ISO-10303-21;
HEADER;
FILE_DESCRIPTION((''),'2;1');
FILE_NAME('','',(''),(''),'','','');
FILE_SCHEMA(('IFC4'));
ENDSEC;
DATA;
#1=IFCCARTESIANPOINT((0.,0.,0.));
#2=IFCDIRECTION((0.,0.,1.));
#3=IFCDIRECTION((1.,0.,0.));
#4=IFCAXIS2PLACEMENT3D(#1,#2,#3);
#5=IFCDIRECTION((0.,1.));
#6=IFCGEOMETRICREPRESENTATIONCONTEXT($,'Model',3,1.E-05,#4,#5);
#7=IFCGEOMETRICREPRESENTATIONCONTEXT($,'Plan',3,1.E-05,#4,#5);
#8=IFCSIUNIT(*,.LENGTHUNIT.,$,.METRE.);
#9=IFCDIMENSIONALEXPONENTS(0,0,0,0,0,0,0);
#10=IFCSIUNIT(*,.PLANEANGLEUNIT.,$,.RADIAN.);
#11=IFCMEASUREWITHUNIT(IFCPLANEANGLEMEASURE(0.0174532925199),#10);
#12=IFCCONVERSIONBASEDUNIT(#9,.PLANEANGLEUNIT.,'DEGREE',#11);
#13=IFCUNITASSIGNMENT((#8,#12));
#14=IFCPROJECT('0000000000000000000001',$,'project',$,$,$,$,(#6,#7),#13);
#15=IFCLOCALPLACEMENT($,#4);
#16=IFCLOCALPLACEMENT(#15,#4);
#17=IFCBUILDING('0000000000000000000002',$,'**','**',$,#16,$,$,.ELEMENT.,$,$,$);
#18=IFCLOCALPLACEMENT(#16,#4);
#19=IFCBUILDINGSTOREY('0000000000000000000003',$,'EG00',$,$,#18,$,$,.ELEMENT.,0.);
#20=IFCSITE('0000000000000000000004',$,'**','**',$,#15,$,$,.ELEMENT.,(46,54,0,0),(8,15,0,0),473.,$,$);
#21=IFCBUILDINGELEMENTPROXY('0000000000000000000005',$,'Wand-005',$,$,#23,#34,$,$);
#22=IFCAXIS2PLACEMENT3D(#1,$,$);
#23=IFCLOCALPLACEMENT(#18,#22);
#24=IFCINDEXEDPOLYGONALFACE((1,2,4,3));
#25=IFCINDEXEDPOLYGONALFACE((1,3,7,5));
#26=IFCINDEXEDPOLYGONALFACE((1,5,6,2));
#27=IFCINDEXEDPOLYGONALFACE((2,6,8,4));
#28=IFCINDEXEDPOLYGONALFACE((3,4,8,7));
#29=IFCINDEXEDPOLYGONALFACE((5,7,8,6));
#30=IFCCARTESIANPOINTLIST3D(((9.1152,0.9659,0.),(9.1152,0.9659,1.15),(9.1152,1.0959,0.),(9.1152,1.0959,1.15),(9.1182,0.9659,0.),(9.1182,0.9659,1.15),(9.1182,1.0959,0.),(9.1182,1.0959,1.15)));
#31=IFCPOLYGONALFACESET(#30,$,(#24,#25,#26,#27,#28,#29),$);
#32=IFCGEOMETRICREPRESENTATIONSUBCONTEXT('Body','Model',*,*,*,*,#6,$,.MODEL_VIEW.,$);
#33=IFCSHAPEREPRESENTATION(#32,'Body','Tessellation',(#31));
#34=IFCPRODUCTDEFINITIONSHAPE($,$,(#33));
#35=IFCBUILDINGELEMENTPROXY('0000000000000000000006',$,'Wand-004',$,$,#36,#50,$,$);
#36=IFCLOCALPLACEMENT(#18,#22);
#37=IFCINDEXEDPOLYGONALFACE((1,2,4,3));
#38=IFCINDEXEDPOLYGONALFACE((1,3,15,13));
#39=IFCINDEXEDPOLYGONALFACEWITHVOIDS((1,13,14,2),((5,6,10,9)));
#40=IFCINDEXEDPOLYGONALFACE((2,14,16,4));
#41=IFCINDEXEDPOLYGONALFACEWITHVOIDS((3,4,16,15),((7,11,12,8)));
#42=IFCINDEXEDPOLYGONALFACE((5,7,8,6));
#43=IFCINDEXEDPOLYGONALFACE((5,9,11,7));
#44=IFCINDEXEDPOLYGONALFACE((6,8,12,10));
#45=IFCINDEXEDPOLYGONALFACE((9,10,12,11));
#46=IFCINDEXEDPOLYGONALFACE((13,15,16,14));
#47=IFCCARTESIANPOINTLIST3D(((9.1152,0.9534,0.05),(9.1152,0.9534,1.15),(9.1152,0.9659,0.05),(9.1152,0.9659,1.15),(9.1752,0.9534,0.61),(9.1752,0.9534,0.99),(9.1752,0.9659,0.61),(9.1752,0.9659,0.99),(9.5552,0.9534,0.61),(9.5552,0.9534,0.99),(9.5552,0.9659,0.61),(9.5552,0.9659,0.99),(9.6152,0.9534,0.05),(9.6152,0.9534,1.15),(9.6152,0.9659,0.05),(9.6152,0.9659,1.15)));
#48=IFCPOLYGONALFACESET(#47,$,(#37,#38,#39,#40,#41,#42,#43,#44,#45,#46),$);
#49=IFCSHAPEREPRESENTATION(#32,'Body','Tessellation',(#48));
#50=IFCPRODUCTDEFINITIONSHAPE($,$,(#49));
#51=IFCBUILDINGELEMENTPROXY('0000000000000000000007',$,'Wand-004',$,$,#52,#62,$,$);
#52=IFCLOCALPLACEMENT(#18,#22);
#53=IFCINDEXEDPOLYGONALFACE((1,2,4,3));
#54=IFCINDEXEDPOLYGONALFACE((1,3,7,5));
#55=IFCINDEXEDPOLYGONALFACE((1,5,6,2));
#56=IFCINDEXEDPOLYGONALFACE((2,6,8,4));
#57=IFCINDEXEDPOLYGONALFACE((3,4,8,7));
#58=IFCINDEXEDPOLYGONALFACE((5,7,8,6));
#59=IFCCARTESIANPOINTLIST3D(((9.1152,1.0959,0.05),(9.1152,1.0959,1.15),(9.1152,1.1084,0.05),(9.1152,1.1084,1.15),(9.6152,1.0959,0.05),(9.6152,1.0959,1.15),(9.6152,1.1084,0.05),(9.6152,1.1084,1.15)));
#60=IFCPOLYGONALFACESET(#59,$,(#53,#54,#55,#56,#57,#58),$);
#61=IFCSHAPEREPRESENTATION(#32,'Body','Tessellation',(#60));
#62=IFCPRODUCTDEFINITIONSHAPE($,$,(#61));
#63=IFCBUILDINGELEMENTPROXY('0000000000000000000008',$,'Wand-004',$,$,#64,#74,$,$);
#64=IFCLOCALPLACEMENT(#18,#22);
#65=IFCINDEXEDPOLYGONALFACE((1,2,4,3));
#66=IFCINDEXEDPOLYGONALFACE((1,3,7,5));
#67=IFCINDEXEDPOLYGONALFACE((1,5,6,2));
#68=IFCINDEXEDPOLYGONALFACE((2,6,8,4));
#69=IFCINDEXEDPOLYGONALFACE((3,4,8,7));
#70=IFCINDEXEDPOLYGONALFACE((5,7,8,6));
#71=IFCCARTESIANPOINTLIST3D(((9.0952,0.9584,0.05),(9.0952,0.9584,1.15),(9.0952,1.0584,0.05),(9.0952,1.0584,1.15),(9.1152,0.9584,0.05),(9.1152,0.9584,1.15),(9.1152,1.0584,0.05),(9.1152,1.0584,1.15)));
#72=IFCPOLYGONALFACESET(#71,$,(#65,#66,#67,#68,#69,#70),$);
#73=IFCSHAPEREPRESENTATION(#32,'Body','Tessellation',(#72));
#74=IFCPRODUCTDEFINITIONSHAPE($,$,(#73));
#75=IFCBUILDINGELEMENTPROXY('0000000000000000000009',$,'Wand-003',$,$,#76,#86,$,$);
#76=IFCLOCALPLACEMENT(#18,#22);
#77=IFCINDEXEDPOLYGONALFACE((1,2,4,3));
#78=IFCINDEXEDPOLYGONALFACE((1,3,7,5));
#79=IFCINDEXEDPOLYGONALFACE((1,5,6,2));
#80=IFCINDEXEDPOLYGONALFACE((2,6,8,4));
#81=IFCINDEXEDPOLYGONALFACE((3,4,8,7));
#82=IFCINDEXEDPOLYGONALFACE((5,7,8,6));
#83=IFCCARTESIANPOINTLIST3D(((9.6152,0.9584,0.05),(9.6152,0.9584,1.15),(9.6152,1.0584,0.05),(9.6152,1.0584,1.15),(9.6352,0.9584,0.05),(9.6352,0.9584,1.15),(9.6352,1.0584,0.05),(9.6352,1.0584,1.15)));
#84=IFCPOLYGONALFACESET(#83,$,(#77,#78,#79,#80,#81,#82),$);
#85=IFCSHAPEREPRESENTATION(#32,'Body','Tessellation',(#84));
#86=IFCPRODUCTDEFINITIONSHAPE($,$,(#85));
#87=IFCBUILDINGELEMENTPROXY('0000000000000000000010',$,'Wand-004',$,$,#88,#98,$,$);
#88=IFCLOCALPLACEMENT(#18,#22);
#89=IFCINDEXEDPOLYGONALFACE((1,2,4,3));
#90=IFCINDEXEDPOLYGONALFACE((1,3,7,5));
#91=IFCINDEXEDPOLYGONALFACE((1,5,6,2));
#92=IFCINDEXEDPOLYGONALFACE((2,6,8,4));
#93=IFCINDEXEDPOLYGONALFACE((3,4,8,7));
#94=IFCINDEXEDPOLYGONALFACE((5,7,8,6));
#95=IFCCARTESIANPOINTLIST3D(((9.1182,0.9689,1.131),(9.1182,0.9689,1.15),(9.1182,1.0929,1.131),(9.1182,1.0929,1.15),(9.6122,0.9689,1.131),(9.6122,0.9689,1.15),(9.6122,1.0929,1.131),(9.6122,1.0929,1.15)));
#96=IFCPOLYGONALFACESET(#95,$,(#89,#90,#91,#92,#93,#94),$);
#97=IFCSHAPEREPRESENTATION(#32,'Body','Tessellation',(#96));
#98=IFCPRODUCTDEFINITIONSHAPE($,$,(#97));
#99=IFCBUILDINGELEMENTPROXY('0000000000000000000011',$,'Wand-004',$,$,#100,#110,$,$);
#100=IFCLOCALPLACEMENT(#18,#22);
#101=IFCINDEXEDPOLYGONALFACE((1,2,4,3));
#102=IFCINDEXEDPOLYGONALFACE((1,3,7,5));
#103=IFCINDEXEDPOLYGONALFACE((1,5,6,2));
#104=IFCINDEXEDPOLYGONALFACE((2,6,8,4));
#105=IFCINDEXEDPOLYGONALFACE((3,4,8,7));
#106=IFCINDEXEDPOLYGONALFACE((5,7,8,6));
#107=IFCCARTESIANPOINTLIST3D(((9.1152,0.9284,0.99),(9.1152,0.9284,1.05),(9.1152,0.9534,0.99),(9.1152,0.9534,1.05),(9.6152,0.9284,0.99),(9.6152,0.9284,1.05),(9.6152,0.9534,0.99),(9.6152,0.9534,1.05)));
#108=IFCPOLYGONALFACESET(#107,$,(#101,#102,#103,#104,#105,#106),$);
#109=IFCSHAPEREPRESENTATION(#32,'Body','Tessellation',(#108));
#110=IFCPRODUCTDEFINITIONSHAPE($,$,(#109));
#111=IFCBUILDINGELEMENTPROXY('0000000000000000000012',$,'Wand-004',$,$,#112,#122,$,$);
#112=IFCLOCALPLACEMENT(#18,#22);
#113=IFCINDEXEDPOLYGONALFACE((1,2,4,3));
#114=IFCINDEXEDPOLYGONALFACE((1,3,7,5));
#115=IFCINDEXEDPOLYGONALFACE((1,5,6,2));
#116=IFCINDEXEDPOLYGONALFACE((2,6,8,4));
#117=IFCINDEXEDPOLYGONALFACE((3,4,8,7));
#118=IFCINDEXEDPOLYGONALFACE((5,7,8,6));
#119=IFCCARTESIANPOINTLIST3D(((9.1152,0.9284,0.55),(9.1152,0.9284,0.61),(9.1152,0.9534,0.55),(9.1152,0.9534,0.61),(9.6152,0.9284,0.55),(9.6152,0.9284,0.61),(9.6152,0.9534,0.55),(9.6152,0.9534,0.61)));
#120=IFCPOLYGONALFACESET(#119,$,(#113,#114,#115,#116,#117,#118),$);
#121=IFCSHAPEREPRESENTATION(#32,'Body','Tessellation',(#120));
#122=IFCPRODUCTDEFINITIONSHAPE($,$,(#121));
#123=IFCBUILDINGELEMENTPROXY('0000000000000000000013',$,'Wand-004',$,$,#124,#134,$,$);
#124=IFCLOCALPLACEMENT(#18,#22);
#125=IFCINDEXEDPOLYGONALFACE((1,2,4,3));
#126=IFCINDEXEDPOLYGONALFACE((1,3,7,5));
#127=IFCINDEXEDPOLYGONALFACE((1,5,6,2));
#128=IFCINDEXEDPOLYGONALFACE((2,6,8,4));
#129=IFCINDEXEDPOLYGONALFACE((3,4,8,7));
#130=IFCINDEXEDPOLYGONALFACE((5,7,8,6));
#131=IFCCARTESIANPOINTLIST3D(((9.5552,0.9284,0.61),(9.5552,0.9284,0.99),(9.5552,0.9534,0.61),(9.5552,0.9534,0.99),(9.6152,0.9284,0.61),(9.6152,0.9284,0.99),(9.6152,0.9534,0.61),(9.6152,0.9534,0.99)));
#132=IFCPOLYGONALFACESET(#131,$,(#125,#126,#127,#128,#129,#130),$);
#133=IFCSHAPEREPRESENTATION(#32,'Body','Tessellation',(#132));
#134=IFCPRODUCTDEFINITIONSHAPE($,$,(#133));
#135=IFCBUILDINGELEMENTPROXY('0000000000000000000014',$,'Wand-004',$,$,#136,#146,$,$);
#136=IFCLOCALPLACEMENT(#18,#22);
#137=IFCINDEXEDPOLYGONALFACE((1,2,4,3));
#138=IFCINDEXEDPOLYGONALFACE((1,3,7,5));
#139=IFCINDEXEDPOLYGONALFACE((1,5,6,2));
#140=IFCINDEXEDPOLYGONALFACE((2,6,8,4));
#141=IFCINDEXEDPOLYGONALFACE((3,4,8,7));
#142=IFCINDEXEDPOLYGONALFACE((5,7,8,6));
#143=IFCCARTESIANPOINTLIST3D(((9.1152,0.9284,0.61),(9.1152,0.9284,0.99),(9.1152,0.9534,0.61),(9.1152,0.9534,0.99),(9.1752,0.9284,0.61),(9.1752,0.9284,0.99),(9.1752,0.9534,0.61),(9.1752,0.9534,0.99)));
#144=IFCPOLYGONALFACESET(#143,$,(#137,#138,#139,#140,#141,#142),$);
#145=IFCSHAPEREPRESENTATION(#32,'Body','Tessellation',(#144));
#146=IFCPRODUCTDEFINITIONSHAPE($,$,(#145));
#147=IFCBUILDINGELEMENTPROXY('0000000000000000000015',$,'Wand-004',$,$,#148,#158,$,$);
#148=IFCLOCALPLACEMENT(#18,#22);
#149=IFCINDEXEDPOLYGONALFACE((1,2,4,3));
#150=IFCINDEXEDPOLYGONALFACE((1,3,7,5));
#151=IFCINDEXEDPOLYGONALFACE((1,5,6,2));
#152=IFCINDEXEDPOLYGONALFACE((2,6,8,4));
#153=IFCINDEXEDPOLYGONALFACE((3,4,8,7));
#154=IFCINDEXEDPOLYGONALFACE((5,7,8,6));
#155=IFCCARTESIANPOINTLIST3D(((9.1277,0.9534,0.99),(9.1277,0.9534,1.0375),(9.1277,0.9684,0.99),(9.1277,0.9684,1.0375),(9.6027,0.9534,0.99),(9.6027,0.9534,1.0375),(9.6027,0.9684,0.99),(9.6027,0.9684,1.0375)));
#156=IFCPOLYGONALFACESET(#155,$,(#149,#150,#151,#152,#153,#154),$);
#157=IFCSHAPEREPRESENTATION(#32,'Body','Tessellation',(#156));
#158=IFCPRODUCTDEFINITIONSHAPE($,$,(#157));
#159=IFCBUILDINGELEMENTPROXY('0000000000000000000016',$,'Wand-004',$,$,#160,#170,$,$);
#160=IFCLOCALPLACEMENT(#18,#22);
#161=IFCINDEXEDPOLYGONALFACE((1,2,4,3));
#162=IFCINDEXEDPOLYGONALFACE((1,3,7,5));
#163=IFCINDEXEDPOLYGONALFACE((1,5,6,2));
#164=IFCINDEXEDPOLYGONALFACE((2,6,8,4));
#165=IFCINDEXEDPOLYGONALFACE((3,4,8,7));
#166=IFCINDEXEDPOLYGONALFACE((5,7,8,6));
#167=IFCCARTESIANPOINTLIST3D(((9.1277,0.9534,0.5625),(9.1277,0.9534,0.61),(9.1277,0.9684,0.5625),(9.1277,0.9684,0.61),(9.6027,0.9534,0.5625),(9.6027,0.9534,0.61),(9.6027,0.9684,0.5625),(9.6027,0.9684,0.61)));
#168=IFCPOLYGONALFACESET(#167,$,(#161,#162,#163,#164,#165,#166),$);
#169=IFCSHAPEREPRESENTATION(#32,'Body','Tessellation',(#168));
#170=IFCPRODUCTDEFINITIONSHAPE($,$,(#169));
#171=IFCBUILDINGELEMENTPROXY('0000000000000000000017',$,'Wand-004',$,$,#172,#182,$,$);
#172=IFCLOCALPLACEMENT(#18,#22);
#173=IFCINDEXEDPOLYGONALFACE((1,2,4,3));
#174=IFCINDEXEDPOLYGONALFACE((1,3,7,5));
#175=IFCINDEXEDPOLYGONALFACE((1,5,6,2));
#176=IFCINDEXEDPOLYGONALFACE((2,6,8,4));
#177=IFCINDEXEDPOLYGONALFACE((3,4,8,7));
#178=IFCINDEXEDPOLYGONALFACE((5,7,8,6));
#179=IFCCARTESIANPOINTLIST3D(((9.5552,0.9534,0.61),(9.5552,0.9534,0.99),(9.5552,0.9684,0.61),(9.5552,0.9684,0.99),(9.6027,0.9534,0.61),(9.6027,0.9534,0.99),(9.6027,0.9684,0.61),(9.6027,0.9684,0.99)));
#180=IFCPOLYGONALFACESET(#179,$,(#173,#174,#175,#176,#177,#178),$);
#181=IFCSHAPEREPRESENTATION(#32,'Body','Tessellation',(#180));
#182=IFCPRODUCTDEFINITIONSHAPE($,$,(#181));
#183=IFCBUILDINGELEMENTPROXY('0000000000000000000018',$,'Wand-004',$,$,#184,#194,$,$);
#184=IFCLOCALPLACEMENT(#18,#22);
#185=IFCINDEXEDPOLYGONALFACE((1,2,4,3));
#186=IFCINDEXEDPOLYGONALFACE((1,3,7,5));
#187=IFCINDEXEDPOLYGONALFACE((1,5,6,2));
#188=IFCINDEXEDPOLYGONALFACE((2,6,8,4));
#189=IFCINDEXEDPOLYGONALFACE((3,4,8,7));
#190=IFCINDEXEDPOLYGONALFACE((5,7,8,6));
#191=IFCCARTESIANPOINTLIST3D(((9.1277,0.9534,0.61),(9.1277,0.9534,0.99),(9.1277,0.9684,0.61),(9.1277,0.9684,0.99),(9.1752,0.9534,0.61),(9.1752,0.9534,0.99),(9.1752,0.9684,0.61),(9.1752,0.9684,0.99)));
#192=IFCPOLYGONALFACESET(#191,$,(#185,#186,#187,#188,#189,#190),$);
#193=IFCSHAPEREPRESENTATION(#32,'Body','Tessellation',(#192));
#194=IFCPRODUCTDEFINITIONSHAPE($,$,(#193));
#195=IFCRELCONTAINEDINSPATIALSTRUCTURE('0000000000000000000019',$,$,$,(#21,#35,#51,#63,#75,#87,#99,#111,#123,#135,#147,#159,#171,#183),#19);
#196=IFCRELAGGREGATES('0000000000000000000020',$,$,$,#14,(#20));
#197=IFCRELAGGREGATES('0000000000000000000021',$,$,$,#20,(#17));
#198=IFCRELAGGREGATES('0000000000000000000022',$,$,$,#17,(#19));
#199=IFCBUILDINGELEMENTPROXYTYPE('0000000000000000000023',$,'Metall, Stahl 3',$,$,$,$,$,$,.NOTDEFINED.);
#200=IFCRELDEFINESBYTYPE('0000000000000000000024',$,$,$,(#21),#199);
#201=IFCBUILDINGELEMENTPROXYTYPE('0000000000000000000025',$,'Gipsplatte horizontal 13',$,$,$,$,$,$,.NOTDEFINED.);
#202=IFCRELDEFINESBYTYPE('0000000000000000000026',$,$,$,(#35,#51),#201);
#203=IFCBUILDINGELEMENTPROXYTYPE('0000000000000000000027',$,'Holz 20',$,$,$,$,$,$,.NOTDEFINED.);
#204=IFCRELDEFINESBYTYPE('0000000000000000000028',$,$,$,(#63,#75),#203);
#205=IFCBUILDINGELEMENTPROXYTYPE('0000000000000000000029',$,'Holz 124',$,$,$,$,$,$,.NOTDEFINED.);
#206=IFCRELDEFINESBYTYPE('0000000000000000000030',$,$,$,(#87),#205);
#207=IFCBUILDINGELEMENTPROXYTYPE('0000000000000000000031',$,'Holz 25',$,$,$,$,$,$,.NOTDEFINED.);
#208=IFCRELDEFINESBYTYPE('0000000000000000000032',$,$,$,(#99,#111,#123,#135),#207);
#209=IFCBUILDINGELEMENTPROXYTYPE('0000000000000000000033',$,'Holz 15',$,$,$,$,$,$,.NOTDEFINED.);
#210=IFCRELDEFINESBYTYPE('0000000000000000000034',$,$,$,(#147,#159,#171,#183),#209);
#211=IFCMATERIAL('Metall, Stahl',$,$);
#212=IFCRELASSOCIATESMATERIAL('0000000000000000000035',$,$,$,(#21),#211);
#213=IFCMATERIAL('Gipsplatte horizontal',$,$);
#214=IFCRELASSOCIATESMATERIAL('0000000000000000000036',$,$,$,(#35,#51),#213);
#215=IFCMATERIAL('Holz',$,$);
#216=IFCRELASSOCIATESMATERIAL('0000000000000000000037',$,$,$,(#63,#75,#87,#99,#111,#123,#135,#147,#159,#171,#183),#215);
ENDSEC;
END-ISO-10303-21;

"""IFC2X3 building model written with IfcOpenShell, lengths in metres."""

from ifc_helpers import new_model, entity, si_unit, converted_unit, direction, frame, origin_with_axes, origin_2d_with_axis, place, context, subcontext, project, spatial, polyline, rectangle, outline, extrude, material, type_object, element, save


model = new_model("IFC2X3")

# Units and contexts
model_context = context("Model", 3, precision=1e-05, world=origin_with_axes(), true_north=direction((0.0, 1.0)))
plan_context = context("Plan", 3, precision=1e-05, world=origin_with_axes(), true_north=direction((0.0, 1.0)))
body_context = subcontext(model_context, "Body", "Model", "MODEL_VIEW")
ifc_project = project(units=[si_unit("LENGTHUNIT", "METRE"), converted_unit("PLANEANGLEUNIT", "DEGREE", entity("IfcPlaneAngleMeasure", 0.0174532925199), si_unit("PLANEANGLEUNIT", "RADIAN"), dimensions=[0, 0, 0, 0, 0, 0, 0])], contexts=[model_context, plan_context])

# Site, building, storey
site_placement = place(None, origin_with_axes())
site = spatial("IfcSite", under=ifc_project, at=site_placement, Name="**", Description="**", CompositionType="ELEMENT", RefLatitude=(46, 54, 0, 0), RefLongitude=(8, 15, 0, 0), RefElevation=473.0)
building_placement = place(site_placement, origin_with_axes())
building = spatial("IfcBuilding", under=site, at=building_placement, Name="**", Description="**", CompositionType="ELEMENT")
storey_placement = place(building_placement, origin_with_axes())
storey = spatial("IfcBuildingStorey", under=building, at=storey_placement, Name="EG00", CompositionType="ELEMENT", Elevation=0.0)

# Building element proxy
ifc_material_1 = material(Name="Metall, Stahl")
building_element_proxy_type_1 = type_object("IfcBuildingElementProxyType", Name="Metall, Stahl 3", PredefinedType="NOTDEFINED")
proxy_1_placement = place(storey_placement, frame((9.1152, 1.0959, 0.0), z_axis=(0.0, 0.0, 1.0), x_axis=(0.0, -1.0, 0.0)))
element("IfcBuildingElementProxy", 1, at=proxy_1_placement, inside=storey, type_object=building_element_proxy_type_1, material=ifc_material_1, Name="Wand-005", context=body_context, shape_type="SweptSolid", body=[
    extrude(outline(polyline([(0.0, 0.0), (0.13, 0.0), (0.13, 0.003), (0.0, 0.003), (0.0, 0.0)])), origin_with_axes(), (0.0, 0.0, 1.0), 1.15),
])

# Building element proxy, opening
ifc_material_2 = material(Name="Gipsplatte horizontal")
building_element_proxy_type_2 = type_object("IfcBuildingElementProxyType", Name="Gipsplatte horizontal 13", PredefinedType="NOTDEFINED")
proxy_2_placement = place(storey_placement, frame((9.1152, 0.9534, 0.05), z_axis=(0.0, 0.0, 1.0), x_axis=(1.0, 0.0, 0.0)))
proxy_2 = element("IfcBuildingElementProxy", 2, at=proxy_2_placement, inside=storey, type_object=building_element_proxy_type_2, material=ifc_material_2, Name="Wand-004", context=body_context, shape_type="SweptSolid", body=[
    extrude(outline(polyline([(0.0, 0.0), (0.5, 0.0), (0.5, 0.0125), (0.0, 0.0125), (0.0, 0.0)])), origin_with_axes(), (0.0, 0.0, 1.0), 1.1),
])
opening_placement = place(proxy_2_placement, frame((-9.1152, -0.9534, -0.05), z_axis=(0.0, 0.0, 1.0), x_axis=(1.0, 0.0, 0.0)))
element("IfcOpeningElement", 3, at=opening_placement, cuts=proxy_2, context=body_context, shape_type="SweptSolid", body=[
    extrude(rectangle(XDim=0.38, YDim=0.38, at=origin_2d_with_axis()), frame((9.3652, 0.9284, 0.8), z_axis=(0.0, -1.0, 0.0), x_axis=(1.0, 0.0, 0.0)), (0.0, 0.0, -1.0), 0.05),
])

# Building element proxies
proxy_3_placement = place(storey_placement, frame((9.1152, 1.1084, 0.05), z_axis=(0.0, 0.0, 1.0), x_axis=(1.0, 0.0, 0.0)))
element("IfcBuildingElementProxy", 4, at=proxy_3_placement, inside=storey, type_object=building_element_proxy_type_2, material=ifc_material_2, Name="Wand-004", context=body_context, shape_type="SweptSolid", body=[
    extrude(outline(polyline([(0.0, -0.0125), (0.5, -0.0125), (0.5, 0.0), (0.0, 0.0), (0.0, -0.0125)])), origin_with_axes(), (0.0, 0.0, 1.0), 1.1),
])
ifc_material_3 = material(Name="Holz")
building_element_proxy_type_3 = type_object("IfcBuildingElementProxyType", Name="Holz 20", PredefinedType="NOTDEFINED")
proxy_4_placement = place(storey_placement, frame((9.0952, 1.0584, 0.05), z_axis=(0.0, 0.0, 1.0), x_axis=(0.0, -1.0, 0.0)))
element("IfcBuildingElementProxy", 5, at=proxy_4_placement, inside=storey, type_object=building_element_proxy_type_3, material=ifc_material_3, Name="Wand-004", context=body_context, shape_type="SweptSolid", body=[
    extrude(outline(polyline([(0.0, 0.0), (0.1, 0.0), (0.1, 0.02), (0.0, 0.02), (0.0, 0.0)])), origin_with_axes(), (0.0, 0.0, 1.0), 1.1),
])
proxy_5_placement = place(storey_placement, frame((9.6352, 1.0584, 0.05), z_axis=(0.0, 0.0, 1.0), x_axis=(0.0, -1.0, 0.0)))
element("IfcBuildingElementProxy", 6, at=proxy_5_placement, inside=storey, type_object=building_element_proxy_type_3, material=ifc_material_3, Name="Wand-003", context=body_context, shape_type="SweptSolid", body=[
    extrude(outline(polyline([(0.0, -0.02), (0.1, -0.02), (0.1, 0.0), (0.0, 0.0), (0.0, -0.02)])), origin_with_axes(), (0.0, 0.0, 1.0), 1.1),
])
building_element_proxy_type_4 = type_object("IfcBuildingElementProxyType", Name="Holz 124", PredefinedType="NOTDEFINED")
proxy_6_placement = place(storey_placement, frame((9.1182, 1.0929, 1.131), z_axis=(0.0, 0.0, 1.0), x_axis=(1.0, 0.0, 0.0)))
element("IfcBuildingElementProxy", 7, at=proxy_6_placement, inside=storey, type_object=building_element_proxy_type_4, material=ifc_material_3, Name="Wand-004", context=body_context, shape_type="SweptSolid", body=[
    extrude(outline(polyline([(0.0, -0.124), (0.494, -0.124), (0.494, 0.0), (0.0, 0.0), (0.0, -0.124)])), origin_with_axes(), (0.0, 0.0, 1.0), 0.019),
])
building_element_proxy_type_5 = type_object("IfcBuildingElementProxyType", Name="Holz 25", PredefinedType="NOTDEFINED")
for number, where, z_axis, x_axis, name in (
    (8, (9.6152, 0.9534, 0.99), (0.0, 0.0, 1.0), (-1.0, 0.0, 0.0), "Wand-004"),
    (9, (9.6152, 0.9534, 0.55), (0.0, 0.0, 1.0), (-1.0, 0.0, 0.0), "Wand-004"),
):
    element("IfcBuildingElementProxy", number, at=place(storey_placement, frame(where, z_axis=z_axis, x_axis=x_axis)), inside=storey, type_object=building_element_proxy_type_5, material=ifc_material_3, Name=name, context=body_context, shape_type="SweptSolid", body=[
        extrude(outline(polyline([(0.0, 0.0), (0.5, 0.0), (0.5, 0.025), (0.0, 0.025), (0.0, 0.0)])), origin_with_axes(), (0.0, 0.0, 1.0), 0.06),
    ])
for number, where, z_axis, x_axis, name in (
    (10, (9.5552, 0.9284, 0.61), (0.0, 0.0, 1.0), (1.0, 0.0, 0.0), "Wand-004"),
    (11, (9.1152, 0.9284, 0.61), (0.0, 0.0, 1.0), (1.0, 0.0, 0.0), "Wand-004"),
):
    element("IfcBuildingElementProxy", number, at=place(storey_placement, frame(where, z_axis=z_axis, x_axis=x_axis)), inside=storey, type_object=building_element_proxy_type_5, material=ifc_material_3, Name=name, context=body_context, shape_type="SweptSolid", body=[
        extrude(outline(polyline([(0.0, 0.0), (0.06, 0.0), (0.06, 0.025), (0.0, 0.025), (0.0, 0.0)])), origin_with_axes(), (0.0, 0.0, 1.0), 0.38),
    ])
building_element_proxy_type_6 = type_object("IfcBuildingElementProxyType", Name="Holz 15", PredefinedType="NOTDEFINED")
for number, where, z_axis, x_axis, name in (
    (12, (9.6027, 0.9684, 0.99), (0.0, 0.0, 1.0), (-1.0, 0.0, 0.0), "Wand-004"),
    (13, (9.6027, 0.9684, 0.5625), (0.0, 0.0, 1.0), (-1.0, 0.0, 0.0), "Wand-004"),
):
    element("IfcBuildingElementProxy", number, at=place(storey_placement, frame(where, z_axis=z_axis, x_axis=x_axis)), inside=storey, type_object=building_element_proxy_type_6, material=ifc_material_3, Name=name, context=body_context, shape_type="SweptSolid", body=[
        extrude(outline(polyline([(0.0, 0.0), (0.475, 0.0), (0.475, 0.015), (0.0, 0.015), (0.0, 0.0)])), origin_with_axes(), (0.0, 0.0, 1.0), 0.0475),
    ])
for number, where, z_axis, x_axis, name in (
    (14, (9.5552, 0.9534, 0.61), (0.0, 0.0, 1.0), (1.0, 0.0, 0.0), "Wand-004"),
    (15, (9.1277, 0.9534, 0.61), (0.0, 0.0, 1.0), (1.0, 0.0, 0.0), "Wand-004"),
):
    element("IfcBuildingElementProxy", number, at=place(storey_placement, frame(where, z_axis=z_axis, x_axis=x_axis)), inside=storey, type_object=building_element_proxy_type_6, material=ifc_material_3, Name=name, context=body_context, shape_type="SweptSolid", body=[
        extrude(outline(polyline([(0.0, 0.0), (0.0475, 0.0), (0.0475, 0.015), (0.0, 0.015), (0.0, 0.0)])), origin_with_axes(), (0.0, 0.0, 1.0), 0.38),
    ])

save(model, "model.ifc")
